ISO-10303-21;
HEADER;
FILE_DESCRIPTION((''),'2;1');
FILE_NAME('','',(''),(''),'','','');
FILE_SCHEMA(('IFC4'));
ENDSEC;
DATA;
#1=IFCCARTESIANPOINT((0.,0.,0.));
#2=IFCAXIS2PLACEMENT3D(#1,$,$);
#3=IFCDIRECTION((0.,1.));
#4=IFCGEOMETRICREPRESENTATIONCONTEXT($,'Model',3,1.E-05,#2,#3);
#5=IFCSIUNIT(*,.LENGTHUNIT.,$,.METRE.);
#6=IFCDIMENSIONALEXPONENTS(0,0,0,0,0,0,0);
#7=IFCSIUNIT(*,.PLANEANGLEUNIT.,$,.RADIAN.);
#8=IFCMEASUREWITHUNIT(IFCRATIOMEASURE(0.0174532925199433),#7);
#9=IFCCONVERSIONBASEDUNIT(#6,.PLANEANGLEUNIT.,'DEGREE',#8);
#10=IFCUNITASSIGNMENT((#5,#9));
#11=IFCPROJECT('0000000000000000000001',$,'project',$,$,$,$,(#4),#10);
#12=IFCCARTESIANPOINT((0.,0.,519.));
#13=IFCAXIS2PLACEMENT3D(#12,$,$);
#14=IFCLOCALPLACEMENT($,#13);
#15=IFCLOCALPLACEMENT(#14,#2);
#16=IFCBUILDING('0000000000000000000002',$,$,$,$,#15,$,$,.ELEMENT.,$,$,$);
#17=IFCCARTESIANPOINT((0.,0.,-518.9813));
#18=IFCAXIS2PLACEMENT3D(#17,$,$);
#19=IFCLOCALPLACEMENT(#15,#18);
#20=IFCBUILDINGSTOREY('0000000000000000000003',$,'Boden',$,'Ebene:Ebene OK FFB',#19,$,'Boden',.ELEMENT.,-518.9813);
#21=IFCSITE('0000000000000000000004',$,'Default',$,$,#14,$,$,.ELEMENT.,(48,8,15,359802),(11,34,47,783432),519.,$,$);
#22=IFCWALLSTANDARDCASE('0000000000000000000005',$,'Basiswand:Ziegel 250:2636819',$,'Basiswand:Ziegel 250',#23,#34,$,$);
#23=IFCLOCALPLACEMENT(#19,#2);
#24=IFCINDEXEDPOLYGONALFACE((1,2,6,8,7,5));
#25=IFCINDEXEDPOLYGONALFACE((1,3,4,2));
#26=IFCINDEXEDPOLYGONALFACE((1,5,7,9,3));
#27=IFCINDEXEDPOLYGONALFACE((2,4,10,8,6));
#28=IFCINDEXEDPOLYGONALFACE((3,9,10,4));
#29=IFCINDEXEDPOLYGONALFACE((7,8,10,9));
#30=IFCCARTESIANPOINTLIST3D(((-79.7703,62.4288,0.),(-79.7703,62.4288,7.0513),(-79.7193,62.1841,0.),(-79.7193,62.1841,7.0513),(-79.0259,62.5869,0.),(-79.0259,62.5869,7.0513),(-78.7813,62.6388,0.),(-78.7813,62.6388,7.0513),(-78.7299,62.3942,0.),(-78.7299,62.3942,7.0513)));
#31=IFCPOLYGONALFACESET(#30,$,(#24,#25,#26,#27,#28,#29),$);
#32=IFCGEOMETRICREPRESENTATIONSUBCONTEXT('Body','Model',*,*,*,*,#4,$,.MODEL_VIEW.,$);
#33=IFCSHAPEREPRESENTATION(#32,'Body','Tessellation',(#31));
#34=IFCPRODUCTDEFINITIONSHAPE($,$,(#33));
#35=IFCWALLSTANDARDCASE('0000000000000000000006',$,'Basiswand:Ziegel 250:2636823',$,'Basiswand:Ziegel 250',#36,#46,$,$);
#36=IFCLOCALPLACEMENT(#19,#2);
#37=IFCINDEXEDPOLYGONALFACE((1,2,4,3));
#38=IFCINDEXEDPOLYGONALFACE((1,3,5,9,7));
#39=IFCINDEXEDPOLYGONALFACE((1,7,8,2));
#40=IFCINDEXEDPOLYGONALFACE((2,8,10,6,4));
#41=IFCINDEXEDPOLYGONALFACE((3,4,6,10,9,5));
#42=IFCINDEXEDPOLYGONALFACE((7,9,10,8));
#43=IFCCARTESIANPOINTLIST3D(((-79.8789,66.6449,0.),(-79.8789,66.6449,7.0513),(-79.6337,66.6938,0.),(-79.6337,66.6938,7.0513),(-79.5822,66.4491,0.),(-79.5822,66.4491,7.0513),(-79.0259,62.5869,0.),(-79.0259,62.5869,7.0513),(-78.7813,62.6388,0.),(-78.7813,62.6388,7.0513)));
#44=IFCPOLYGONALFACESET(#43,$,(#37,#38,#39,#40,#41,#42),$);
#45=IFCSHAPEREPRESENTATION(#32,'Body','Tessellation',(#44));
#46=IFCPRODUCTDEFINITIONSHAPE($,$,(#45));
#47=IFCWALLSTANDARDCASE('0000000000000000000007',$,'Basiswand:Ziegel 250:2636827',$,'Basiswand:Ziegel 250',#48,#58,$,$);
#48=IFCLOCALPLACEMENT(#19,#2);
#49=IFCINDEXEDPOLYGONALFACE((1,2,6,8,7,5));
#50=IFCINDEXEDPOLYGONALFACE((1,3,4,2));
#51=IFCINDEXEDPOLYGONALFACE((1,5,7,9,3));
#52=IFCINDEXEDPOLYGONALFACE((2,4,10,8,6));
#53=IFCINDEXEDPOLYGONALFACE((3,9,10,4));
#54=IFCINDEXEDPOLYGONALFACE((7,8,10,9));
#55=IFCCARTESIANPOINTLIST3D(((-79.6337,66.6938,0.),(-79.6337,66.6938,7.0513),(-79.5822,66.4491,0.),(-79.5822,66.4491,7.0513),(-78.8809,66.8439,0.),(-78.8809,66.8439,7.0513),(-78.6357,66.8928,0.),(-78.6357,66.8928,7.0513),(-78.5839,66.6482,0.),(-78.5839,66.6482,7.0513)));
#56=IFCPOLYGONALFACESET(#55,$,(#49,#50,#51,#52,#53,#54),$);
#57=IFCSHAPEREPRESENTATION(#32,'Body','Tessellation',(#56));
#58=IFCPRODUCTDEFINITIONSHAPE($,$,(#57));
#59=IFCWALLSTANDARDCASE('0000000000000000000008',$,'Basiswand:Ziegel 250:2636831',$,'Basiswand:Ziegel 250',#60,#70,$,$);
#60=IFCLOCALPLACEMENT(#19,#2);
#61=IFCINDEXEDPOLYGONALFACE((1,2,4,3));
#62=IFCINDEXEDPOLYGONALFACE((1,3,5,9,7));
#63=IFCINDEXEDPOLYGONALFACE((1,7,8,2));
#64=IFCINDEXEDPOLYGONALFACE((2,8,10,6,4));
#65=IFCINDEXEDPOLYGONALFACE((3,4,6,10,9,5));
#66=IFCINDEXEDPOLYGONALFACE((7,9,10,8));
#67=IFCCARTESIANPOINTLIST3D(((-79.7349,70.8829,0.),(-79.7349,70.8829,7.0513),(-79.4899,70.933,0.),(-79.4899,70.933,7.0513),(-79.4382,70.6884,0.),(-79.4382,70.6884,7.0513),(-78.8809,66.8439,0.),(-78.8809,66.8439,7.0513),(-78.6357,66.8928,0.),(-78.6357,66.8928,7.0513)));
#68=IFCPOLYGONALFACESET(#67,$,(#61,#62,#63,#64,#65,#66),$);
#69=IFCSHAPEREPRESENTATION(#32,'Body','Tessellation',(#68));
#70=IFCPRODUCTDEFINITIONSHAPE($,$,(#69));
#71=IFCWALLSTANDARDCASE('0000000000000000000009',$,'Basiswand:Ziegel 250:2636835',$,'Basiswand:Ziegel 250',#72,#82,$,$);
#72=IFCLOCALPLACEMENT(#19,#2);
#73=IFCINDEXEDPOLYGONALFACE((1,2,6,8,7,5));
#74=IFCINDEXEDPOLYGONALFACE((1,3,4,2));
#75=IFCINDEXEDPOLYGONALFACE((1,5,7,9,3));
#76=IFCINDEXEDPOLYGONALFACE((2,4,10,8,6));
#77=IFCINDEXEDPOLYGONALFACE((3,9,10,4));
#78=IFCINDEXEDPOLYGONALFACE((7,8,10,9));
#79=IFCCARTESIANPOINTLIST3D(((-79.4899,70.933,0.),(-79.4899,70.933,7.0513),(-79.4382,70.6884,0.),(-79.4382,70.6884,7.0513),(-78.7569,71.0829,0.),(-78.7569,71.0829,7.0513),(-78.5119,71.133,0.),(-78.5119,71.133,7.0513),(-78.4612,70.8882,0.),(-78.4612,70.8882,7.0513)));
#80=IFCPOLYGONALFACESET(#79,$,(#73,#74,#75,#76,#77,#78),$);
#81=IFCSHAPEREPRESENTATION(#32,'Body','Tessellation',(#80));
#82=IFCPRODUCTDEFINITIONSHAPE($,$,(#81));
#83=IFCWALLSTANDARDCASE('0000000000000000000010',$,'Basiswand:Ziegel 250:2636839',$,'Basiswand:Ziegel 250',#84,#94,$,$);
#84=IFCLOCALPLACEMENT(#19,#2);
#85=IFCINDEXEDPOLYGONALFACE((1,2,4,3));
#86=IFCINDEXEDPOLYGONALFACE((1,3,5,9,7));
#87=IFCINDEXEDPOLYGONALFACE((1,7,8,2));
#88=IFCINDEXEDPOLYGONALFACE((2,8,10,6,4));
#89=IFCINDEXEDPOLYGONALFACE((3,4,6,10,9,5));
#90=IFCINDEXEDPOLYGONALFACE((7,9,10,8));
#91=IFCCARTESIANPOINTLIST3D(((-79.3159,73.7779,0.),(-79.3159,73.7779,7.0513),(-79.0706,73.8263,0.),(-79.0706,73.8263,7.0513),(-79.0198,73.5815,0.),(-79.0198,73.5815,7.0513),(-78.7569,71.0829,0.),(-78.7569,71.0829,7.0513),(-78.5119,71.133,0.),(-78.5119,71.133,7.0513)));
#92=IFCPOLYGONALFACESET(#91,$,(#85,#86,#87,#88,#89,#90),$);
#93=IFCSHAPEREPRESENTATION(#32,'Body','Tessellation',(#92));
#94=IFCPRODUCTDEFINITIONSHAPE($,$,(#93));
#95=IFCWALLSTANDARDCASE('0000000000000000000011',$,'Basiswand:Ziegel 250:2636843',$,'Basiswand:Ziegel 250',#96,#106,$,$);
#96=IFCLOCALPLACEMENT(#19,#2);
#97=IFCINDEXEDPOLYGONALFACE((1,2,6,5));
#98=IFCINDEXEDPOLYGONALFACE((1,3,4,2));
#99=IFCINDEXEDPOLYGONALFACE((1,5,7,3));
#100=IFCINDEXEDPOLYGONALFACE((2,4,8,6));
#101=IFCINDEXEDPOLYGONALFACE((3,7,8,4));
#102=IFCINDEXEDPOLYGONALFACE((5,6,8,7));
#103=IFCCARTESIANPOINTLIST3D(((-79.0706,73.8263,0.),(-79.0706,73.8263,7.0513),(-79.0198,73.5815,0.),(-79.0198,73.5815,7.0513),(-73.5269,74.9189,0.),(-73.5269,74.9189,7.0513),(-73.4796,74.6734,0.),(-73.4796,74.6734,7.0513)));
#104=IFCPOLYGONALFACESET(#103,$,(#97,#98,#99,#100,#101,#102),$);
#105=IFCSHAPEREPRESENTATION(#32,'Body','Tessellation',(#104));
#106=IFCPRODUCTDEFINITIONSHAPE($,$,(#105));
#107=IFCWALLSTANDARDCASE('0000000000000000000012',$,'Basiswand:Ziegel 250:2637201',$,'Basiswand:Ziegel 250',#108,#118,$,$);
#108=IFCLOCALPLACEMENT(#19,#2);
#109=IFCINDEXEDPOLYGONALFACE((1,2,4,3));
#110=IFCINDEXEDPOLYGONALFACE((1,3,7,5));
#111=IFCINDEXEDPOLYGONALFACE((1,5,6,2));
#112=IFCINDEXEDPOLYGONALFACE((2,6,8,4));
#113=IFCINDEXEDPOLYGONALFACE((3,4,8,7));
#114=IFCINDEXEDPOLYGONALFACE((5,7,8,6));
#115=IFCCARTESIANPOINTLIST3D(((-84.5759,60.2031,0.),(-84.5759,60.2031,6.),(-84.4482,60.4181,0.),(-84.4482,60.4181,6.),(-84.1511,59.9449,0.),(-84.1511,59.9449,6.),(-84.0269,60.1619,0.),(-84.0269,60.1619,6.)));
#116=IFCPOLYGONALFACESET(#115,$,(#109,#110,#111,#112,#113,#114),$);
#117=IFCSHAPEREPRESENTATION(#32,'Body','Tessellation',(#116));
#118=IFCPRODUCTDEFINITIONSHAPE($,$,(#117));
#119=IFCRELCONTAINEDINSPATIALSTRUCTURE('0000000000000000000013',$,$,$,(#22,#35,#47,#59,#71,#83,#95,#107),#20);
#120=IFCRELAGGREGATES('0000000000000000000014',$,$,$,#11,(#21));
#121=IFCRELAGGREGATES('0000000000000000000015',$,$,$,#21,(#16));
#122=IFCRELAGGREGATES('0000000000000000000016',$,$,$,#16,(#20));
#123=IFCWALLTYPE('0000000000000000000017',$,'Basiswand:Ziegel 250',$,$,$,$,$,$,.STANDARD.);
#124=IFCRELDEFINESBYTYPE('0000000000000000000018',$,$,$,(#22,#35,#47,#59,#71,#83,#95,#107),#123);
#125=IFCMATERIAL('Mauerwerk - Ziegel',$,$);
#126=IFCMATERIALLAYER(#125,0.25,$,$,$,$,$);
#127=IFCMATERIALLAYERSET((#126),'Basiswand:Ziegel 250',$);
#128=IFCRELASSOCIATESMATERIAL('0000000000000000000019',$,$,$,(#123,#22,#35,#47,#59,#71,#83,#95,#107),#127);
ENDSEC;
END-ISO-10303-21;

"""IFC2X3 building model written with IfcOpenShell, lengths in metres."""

from ifc_helpers import new_model, entity, si_unit, converted_unit, direction, frame, origin, place, context, subcontext, project, spatial, polyline, outline, extrude, clip, bounded_halfspace, material, layer, layer_set, layer_usage, type_object, element, save


model = new_model("IFC2X3")

# Units and contexts
model_context = context("Model", 3, precision=1e-05, world=origin(), true_north=direction((0.0, 1.0)))
body_context = subcontext(model_context, "Body", "Model", "MODEL_VIEW")
ifc_project = project(units=[si_unit("LENGTHUNIT", "METRE"), converted_unit("PLANEANGLEUNIT", "DEGREE", entity("IfcRatioMeasure", 0.0174532925199433), si_unit("PLANEANGLEUNIT", "RADIAN"), dimensions=[0, 0, 0, 0, 0, 0, 0])], contexts=[model_context])

# Site, building, storey
site_placement = place(None, frame((0.0, 0.0, 519.0)))
site = spatial("IfcSite", under=ifc_project, at=site_placement, Name="Default", CompositionType="ELEMENT", RefLatitude=(48, 8, 15, 359802), RefLongitude=(11, 34, 47, 783432), RefElevation=519.0)
building_placement = place(site_placement, origin())
building = spatial("IfcBuilding", under=site, at=building_placement, CompositionType="ELEMENT")
storey_placement = place(building_placement, frame((0.0, 0.0, -518.9813)))
storey = spatial("IfcBuildingStorey", under=building, at=storey_placement, Name="Boden", ObjectType="Ebene:Ebene OK FFB", LongName="Boden", CompositionType="ELEMENT", Elevation=-518.9813)

# Walls
ifc_material_1 = material(Name="Mauerwerk - Ziegel")
ifc_layer_1 = layer(ifc_material_1, 0.25)
ifc_layer_set_1 = layer_set([ifc_layer_1], Name="Basiswand:Ziegel 250")
wall_type_1 = type_object("IfcWallType", Name="Basiswand:Ziegel 250", PredefinedType="STANDARD", material=ifc_layer_set_1)
ifc_layer_usage_1 = layer_usage(ifc_layer_set_1, "AXIS2", "NEGATIVE", 0.125)
wall_1_placement = place(storey_placement, frame((-79.7452, 62.3064, 0.0), z_axis=(0.0, 0.0, 1.0), x_axis=(0.978192, 0.207705, 0.0)))
element("IfcWallStandardCase", 1, at=wall_1_placement, inside=storey, type_object=wall_type_1, material=ifc_layer_usage_1, Name="Basiswand:Ziegel 250:2636819", ObjectType="Basiswand:Ziegel 250", context=body_context, shape_type="SweptSolid", body=[
    extrude(outline(polyline([(1.0115, -0.125), (1.012, 0.125), (0.762, 0.125), (0.0009, 0.125), (0.0, -0.125), (1.0115, -0.125)])), origin(), (0.0, 0.0, 1.0), 7.0513),
])
ifc_layer_usage_2 = layer_usage(ifc_layer_set_1, "AXIS2", "NEGATIVE", 0.125)
wall_2_placement = place(storey_placement, frame((-78.9035, 62.6126, 0.0), z_axis=(0.0, 0.0, 1.0), x_axis=(-0.205707, 0.978614, 0.0)))
element("IfcWallStandardCase", 2, at=wall_2_placement, inside=storey, type_object=wall_type_1, material=ifc_layer_usage_2, Name="Basiswand:Ziegel 250:2636823", ObjectType="Basiswand:Ziegel 250", context=body_context, shape_type="SweptSolid", body=[
    extrude(outline(polyline([(4.1441, -0.125), (4.1467, 0.125), (0.0, 0.125), (0.0005, -0.125), (3.8941, -0.125), (4.1441, -0.125)])), origin(), (0.0, 0.0, 1.0), 7.0513),
])
ifc_layer_usage_3 = layer_usage(ifc_layer_set_1, "AXIS2", "NEGATIVE", 0.125)
wall_3_placement = place(storey_placement, frame((-79.6092, 66.5712, 0.0), z_axis=(0.0, 0.0, 1.0), x_axis=(0.980694, 0.195549, 0.0)))
element("IfcWallStandardCase", 3, at=wall_3_placement, inside=storey, type_object=wall_type_1, material=ifc_layer_usage_3, Name="Basiswand:Ziegel 250:2636827", ObjectType="Basiswand:Ziegel 250", context=body_context, shape_type="SweptSolid", body=[
    extrude(outline(polyline([(1.0205, -0.125), (1.0177, 0.125), (0.7676, 0.125), (0.0, 0.125), (0.0026, -0.125), (1.0205, -0.125)])), origin(), (0.0, 0.0, 1.0), 7.0513),
])
ifc_layer_usage_4 = layer_usage(ifc_layer_set_1, "AXIS2", "NEGATIVE", 0.125)
wall_4_placement = place(storey_placement, frame((-78.758, 66.867, 0.0), z_axis=(0.0, 0.0, 1.0), x_axis=(-0.206865, 0.97837, 0.0)))
element("IfcWallStandardCase", 4, at=wall_4_placement, inside=storey, type_object=wall_type_1, material=ifc_layer_usage_4, Name="Basiswand:Ziegel 250:2636831", ObjectType="Basiswand:Ziegel 250", context=body_context, shape_type="SweptSolid", body=[
    extrude(outline(polyline([(4.1295, -0.125), (4.1312, 0.125), (0.0029, 0.125), (0.0, -0.125), (3.8795, -0.125), (4.1295, -0.125)])), origin(), (0.0, 0.0, 1.0), 7.0513),
])
ifc_layer_usage_5 = layer_usage(ifc_layer_set_1, "AXIS2", "NEGATIVE", 0.125)
wall_5_placement = place(storey_placement, frame((-79.4649, 70.8105, 0.0), z_axis=(0.0, 0.0, 1.0), x_axis=(0.979724, 0.200353, 0.0)))
element("IfcWallStandardCase", 5, at=wall_5_placement, inside=storey, type_object=wall_type_1, material=ifc_layer_usage_5, Name="Basiswand:Ziegel 250:2636835", ObjectType="Basiswand:Ziegel 250", context=body_context, shape_type="SweptSolid", body=[
    extrude(outline(polyline([(0.9989, -0.125), (0.9982, 0.125), (0.7482, 0.125), (0.0, 0.125), (0.0017, -0.125), (0.9989, -0.125)])), origin(), (0.0, 0.0, 1.0), 7.0513),
])
ifc_layer_usage_6 = layer_usage(ifc_layer_set_1, "AXIS2", "NEGATIVE", 0.125)
wall_6_placement = place(storey_placement, frame((-78.6343, 71.1076, 0.0), z_axis=(0.0, 0.0, 1.0), x_axis=(-0.203098, 0.979158, 0.0)))
element("IfcWallStandardCase", 6, at=wall_6_placement, inside=storey, type_object=wall_type_1, material=ifc_layer_usage_6, Name="Basiswand:Ziegel 250:2636839", ObjectType="Basiswand:Ziegel 250", context=body_context, shape_type="SweptSolid", body=[
    extrude(outline(polyline([(2.7506, -0.125), (2.7531, 0.125), (0.0007, 0.125), (0.0, -0.125), (2.5006, -0.125), (2.7506, -0.125)])), origin(), (0.0, 0.0, 1.0), 7.0513),
])
ifc_layer_usage_7 = layer_usage(ifc_layer_set_1, "AXIS2", "NEGATIVE", 0.125)
wall_7_placement = place(storey_placement, frame((-79.0464, 73.7036, 0.0), z_axis=(0.0, 0.0, 1.0), x_axis=(0.981124, 0.193378, 0.0)))
element("IfcWallStandardCase", 7, at=wall_7_placement, inside=storey, type_object=wall_type_1, material=ifc_layer_usage_7, Name="Basiswand:Ziegel 250:2636843", ObjectType="Basiswand:Ziegel 250", context=body_context, shape_type="SweptSolid", body=[
    extrude(outline(polyline([(5.6493, -0.125), (5.6504, 0.125), (0.0, 0.125), (0.0025, -0.125), (5.6493, -0.125)])), origin(), (0.0, 0.0, 1.0), 7.0513),
])
ifc_layer_usage_8 = layer_usage(ifc_layer_set_1, "AXIS2", "NEGATIVE", 0.125)
wall_8_placement = place(storey_placement, frame((-84.5132, 60.3112, 0.0), z_axis=(0.0, 0.0, 1.0), x_axis=(0.85451, -0.519435, 0.0)))
element("IfcWallStandardCase", 8, at=wall_8_placement, inside=storey, type_object=wall_type_1, material=ifc_layer_usage_8, Name="Basiswand:Ziegel 250:2637201", ObjectType="Basiswand:Ziegel 250", context=body_context, shape_type="Clipping", body=[
    clip(extrude(outline(polyline([(0.4996, -0.125), (0.4931, 0.125), (0.0, 0.125), (0.0025, -0.125), (0.2496, -0.125), (0.4996, -0.125)])), origin(), (0.0, 0.0, 1.0), 6.0), bounded_halfspace(frame((0.0025, -0.125, 6.0), z_axis=(0.0, 0.0, 1.0), x_axis=(-0.02616, 0.999658, 0.0)), False, frame((0.0025, -0.125, 6.0)), polyline([(0.0, 0.0), (0.2471, 0.0), (0.4971, 0.0), (0.4906, 0.25), (-0.0025, 0.25), (0.0, 0.0)]))),
])

save(model, "model.ifc")
